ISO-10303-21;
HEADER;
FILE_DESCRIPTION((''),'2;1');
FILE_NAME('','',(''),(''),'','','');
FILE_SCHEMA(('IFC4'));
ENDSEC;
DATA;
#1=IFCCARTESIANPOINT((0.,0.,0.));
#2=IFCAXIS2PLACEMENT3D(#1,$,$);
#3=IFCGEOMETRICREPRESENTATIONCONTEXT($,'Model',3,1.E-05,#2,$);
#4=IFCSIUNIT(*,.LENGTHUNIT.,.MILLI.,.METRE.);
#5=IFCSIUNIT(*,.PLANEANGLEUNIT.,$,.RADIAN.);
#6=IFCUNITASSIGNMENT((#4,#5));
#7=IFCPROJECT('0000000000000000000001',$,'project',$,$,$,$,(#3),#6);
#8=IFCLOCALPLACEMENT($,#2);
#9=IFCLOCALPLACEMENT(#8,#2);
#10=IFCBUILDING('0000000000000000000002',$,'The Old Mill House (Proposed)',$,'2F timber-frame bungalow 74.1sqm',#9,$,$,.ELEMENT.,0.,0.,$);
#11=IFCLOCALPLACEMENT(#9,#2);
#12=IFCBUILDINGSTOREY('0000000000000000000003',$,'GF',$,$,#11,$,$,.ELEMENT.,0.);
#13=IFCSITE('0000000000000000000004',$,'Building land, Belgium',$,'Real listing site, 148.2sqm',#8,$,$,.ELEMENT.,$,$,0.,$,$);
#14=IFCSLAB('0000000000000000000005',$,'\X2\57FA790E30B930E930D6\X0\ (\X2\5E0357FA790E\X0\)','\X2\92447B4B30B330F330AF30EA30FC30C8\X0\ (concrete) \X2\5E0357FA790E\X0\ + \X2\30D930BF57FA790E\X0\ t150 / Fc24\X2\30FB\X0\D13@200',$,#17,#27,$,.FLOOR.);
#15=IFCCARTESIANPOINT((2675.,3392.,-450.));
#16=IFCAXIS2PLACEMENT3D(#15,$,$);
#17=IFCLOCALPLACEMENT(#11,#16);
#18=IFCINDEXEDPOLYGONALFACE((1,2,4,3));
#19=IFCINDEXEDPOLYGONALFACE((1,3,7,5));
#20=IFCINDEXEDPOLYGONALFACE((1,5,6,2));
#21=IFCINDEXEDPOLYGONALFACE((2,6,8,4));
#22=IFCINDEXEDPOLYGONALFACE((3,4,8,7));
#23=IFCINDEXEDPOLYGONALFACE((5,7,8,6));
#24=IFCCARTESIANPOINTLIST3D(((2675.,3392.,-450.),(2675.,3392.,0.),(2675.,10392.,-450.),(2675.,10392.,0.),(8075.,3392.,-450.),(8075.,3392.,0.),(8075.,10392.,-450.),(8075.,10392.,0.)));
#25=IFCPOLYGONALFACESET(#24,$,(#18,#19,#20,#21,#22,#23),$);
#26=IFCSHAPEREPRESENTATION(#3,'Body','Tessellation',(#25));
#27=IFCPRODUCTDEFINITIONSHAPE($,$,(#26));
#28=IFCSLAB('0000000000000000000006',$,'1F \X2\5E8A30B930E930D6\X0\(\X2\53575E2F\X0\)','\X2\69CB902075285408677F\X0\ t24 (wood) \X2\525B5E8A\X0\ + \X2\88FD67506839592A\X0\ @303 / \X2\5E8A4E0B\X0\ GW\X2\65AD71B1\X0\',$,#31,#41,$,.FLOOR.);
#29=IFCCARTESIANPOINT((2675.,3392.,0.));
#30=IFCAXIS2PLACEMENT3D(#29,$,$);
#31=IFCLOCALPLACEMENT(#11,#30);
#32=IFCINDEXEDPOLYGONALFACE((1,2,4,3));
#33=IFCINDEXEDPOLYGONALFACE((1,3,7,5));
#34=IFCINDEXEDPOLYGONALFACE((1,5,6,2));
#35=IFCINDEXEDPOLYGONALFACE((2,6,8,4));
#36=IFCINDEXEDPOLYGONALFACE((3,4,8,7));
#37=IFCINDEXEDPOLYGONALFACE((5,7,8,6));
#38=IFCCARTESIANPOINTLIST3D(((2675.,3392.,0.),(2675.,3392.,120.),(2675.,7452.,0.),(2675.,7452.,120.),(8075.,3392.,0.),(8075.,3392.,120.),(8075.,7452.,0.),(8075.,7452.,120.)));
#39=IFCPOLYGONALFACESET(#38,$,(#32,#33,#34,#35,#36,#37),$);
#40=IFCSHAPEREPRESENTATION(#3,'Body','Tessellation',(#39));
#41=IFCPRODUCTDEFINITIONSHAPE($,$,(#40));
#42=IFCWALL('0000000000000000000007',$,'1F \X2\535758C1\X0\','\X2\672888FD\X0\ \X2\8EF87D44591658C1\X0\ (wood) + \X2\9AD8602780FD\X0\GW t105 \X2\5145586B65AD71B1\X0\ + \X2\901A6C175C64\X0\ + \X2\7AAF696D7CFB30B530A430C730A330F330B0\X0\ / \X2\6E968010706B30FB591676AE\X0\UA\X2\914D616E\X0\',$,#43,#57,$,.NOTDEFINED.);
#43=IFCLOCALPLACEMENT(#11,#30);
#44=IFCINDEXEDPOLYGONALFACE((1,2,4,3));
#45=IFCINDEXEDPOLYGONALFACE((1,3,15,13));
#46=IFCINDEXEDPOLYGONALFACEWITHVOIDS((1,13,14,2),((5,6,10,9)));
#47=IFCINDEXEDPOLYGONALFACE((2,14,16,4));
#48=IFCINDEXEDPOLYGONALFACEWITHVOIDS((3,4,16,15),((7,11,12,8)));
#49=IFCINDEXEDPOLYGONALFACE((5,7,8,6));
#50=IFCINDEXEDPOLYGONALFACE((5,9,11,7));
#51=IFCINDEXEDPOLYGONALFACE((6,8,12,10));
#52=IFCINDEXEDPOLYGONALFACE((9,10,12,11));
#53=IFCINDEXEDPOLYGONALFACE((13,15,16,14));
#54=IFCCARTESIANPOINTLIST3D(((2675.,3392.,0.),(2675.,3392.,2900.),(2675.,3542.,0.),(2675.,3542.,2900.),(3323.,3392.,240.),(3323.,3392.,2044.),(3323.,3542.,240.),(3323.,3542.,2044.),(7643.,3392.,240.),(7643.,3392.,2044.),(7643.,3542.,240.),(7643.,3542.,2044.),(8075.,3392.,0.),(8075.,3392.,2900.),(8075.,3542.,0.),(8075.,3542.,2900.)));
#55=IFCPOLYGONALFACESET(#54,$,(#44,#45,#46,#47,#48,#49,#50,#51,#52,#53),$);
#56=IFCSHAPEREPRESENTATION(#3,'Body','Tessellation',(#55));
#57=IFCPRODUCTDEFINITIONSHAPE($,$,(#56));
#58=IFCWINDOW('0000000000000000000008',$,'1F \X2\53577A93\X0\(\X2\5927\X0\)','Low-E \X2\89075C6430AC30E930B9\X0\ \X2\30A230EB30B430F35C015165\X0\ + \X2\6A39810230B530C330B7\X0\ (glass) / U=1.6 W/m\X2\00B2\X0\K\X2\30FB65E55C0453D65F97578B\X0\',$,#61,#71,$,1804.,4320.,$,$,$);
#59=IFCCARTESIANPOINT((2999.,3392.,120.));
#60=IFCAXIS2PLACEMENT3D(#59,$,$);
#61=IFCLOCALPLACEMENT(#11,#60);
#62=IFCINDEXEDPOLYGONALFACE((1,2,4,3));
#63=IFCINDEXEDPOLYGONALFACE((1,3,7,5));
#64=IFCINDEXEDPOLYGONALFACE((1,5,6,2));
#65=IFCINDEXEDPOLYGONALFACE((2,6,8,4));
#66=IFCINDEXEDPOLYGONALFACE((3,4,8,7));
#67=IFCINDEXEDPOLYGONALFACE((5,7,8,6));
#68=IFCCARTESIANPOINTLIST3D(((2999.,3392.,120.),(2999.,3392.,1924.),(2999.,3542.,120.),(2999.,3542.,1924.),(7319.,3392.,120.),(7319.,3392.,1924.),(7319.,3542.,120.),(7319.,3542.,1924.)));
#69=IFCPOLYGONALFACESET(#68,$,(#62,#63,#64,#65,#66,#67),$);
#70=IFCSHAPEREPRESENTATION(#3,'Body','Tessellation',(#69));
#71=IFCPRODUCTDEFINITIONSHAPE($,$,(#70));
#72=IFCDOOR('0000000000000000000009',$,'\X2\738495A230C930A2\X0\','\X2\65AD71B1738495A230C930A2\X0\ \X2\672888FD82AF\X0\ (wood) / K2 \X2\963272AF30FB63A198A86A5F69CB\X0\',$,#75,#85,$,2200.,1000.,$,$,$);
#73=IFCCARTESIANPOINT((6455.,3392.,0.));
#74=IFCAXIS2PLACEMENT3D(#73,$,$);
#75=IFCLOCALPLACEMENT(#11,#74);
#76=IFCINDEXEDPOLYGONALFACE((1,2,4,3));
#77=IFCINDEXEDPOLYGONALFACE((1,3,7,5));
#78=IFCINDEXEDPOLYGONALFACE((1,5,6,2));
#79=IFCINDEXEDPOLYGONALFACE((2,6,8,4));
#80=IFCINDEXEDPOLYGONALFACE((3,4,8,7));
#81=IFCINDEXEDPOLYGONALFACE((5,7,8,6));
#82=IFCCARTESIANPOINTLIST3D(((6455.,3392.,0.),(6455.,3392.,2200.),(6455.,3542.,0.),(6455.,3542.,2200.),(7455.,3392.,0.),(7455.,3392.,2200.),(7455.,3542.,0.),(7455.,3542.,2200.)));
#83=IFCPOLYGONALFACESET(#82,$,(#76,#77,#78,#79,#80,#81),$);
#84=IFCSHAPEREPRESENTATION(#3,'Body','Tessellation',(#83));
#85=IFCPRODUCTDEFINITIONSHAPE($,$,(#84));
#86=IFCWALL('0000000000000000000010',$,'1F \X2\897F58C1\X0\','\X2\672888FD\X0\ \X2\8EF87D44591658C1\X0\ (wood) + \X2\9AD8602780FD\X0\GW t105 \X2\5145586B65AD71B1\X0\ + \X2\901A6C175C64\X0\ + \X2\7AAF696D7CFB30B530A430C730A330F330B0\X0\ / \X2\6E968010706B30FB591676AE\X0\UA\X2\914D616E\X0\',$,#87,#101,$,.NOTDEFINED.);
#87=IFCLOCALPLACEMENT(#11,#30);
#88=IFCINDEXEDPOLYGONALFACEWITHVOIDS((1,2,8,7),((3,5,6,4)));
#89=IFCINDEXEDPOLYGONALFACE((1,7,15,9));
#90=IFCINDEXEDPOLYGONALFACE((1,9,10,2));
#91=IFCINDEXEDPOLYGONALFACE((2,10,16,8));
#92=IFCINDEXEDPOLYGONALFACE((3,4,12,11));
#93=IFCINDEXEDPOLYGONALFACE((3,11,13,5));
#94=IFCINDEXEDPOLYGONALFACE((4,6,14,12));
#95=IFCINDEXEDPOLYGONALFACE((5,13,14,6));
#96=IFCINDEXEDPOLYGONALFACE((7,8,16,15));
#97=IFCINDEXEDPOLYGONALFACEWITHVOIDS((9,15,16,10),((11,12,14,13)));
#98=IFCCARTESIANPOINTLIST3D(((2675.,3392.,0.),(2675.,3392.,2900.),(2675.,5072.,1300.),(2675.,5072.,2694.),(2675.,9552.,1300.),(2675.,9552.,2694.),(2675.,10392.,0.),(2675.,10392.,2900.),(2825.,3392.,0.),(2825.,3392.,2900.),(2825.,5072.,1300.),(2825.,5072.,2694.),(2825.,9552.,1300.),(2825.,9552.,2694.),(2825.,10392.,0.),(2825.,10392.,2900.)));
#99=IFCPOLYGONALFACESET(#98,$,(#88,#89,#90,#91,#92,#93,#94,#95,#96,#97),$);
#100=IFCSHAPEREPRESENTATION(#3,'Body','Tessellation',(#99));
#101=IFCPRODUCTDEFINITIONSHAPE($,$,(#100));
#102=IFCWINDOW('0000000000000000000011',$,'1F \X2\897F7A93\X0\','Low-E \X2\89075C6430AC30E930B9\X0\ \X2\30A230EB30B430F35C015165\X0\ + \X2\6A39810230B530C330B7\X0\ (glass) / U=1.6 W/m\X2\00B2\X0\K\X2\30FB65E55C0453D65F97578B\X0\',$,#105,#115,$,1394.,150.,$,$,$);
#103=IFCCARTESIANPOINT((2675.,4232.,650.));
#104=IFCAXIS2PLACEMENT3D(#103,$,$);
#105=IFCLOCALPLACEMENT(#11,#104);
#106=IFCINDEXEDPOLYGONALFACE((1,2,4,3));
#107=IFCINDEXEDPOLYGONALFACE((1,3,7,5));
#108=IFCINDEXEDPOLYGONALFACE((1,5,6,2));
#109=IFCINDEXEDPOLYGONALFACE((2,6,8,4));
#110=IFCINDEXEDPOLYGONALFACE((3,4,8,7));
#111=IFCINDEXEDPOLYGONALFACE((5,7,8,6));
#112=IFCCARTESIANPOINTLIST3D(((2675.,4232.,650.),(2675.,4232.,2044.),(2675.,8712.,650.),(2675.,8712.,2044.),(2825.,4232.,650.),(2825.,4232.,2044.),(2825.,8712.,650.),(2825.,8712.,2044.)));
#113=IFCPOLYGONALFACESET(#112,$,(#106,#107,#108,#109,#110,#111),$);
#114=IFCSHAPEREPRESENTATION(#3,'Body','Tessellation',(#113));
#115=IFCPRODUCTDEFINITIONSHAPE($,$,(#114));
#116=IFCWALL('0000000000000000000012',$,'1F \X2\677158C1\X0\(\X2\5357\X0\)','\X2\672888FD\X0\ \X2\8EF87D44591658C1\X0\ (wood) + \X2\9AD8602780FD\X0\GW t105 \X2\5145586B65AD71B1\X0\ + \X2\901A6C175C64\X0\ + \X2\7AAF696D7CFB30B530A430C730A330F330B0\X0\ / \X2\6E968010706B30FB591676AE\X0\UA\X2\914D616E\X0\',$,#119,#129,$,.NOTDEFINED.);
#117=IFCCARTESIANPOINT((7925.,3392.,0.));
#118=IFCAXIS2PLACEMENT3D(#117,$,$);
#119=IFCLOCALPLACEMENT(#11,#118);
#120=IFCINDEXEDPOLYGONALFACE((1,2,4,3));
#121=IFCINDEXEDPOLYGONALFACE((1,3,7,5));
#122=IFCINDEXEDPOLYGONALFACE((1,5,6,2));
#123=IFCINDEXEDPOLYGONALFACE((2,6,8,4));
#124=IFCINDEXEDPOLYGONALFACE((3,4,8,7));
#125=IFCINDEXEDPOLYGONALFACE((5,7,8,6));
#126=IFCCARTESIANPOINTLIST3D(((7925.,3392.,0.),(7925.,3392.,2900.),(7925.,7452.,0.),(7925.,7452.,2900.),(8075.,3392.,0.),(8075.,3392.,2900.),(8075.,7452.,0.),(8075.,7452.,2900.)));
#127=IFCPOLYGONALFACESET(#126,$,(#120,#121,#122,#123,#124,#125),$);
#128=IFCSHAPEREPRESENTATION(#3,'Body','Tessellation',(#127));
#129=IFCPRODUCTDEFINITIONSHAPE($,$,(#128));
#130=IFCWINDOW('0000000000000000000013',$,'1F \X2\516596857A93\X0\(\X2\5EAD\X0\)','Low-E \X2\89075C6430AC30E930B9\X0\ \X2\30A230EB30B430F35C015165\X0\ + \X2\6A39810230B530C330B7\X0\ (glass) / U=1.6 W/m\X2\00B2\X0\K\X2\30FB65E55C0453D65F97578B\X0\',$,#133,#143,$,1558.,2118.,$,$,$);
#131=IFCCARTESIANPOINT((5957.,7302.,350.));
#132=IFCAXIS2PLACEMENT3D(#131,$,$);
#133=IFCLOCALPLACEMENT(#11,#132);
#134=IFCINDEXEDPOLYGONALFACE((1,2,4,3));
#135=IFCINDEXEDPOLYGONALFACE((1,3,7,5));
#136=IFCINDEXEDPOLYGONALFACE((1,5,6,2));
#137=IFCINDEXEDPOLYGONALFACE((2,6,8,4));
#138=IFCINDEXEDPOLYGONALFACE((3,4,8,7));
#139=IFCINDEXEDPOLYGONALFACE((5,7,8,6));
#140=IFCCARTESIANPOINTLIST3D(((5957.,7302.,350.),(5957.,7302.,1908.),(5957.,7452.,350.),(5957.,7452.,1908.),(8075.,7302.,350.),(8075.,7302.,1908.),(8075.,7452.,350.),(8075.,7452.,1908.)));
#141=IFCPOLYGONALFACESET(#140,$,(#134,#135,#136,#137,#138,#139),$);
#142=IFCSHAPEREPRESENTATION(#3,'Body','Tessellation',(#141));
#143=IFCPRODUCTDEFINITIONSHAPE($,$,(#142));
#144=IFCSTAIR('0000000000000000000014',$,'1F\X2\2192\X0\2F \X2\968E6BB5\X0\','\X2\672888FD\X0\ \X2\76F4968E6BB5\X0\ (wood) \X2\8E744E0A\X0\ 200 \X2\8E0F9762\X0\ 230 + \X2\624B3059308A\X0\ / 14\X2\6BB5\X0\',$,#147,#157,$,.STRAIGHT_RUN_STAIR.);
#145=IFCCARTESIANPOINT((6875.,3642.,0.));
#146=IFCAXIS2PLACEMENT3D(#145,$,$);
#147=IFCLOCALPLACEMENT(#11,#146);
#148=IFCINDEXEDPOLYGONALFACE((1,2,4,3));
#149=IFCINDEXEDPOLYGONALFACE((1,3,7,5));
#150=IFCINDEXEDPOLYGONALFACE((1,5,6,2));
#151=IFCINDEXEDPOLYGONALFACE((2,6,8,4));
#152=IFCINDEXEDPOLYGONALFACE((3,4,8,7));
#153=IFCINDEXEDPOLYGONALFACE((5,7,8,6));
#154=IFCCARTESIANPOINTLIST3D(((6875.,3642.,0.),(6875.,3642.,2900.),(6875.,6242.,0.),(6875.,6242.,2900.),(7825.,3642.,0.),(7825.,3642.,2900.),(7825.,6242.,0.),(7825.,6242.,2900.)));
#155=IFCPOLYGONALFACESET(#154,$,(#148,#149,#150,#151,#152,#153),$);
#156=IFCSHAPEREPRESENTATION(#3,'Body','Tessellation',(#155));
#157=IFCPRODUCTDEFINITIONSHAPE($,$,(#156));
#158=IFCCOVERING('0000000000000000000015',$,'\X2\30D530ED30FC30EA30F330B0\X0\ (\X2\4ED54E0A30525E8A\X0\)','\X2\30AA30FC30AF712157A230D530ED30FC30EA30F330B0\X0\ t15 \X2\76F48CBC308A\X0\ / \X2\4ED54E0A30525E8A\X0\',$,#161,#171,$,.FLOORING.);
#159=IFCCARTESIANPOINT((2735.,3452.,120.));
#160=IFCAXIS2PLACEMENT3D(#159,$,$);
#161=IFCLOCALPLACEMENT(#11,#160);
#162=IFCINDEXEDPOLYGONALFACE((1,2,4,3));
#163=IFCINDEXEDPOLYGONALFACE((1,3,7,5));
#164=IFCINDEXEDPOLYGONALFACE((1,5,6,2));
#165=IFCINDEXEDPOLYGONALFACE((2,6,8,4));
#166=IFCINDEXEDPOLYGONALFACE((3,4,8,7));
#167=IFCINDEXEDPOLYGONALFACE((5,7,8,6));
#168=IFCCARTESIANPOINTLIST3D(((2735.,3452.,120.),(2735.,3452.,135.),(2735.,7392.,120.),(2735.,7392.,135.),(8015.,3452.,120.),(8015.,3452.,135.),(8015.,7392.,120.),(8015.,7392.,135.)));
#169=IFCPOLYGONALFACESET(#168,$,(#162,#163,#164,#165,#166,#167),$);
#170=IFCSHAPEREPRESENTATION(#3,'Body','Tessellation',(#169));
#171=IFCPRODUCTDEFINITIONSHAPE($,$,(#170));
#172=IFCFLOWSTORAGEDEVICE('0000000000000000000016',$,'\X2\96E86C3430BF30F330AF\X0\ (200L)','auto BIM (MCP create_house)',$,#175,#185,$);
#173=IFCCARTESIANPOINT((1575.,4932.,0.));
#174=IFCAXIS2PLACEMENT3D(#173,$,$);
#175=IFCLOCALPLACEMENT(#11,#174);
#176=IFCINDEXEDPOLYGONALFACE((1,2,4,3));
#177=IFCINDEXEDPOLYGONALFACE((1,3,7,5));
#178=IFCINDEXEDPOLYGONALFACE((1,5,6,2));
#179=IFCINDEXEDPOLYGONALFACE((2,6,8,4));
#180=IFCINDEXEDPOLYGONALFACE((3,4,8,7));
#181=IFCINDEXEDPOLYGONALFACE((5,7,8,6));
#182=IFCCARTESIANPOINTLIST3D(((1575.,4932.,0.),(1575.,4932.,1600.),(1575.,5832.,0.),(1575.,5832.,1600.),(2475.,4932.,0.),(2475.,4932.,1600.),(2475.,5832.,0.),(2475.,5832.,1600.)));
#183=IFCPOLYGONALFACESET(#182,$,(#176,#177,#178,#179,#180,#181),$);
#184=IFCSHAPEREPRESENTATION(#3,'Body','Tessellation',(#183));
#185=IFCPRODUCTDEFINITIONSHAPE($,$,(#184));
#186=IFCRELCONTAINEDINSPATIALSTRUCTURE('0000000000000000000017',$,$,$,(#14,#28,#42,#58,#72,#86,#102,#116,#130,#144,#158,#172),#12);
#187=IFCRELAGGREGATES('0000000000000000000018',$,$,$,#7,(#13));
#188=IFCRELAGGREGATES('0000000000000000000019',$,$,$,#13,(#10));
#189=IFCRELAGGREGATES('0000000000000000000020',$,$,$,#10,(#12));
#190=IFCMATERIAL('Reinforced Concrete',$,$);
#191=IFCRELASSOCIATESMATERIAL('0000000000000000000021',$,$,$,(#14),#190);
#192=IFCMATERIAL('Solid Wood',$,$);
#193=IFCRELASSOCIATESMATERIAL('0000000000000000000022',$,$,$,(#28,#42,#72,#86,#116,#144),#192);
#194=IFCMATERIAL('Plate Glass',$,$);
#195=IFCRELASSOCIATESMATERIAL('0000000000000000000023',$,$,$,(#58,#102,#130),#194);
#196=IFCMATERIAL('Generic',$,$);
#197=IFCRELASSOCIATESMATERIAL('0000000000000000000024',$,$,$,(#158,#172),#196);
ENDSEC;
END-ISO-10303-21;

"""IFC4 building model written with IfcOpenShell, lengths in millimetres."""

from ifc_helpers import new_model, si_unit, frame, frame_2d, origin, place, context, project, spatial, rectangle, extrude, material, element, fill, save


model = new_model("IFC4")

# Units and contexts
model_context = context("Model", 3, precision=1e-05, world=origin())
ifc_project = project(units=[si_unit("LENGTHUNIT", "METRE", prefix="MILLI"), si_unit("PLANEANGLEUNIT", "RADIAN")], contexts=[model_context])

# Site, building, storey
site_placement = place(None, origin())
site = spatial("IfcSite", under=ifc_project, at=site_placement, Name="Building land, Belgium", ObjectType="Real listing site, 148.2sqm", CompositionType="ELEMENT", RefElevation=0.0)
building_placement = place(site_placement, origin())
building = spatial("IfcBuilding", under=site, at=building_placement, Name="The Old Mill House (Proposed)", ObjectType="2F timber-frame bungalow 74.1sqm", CompositionType="ELEMENT", ElevationOfRefHeight=0.0, ElevationOfTerrain=0.0)
storey_placement = place(building_placement, origin())
storey = spatial("IfcBuildingStorey", under=building, at=storey_placement, Name="GF", CompositionType="ELEMENT", Elevation=0.0)

# Slabs
ifc_material_1 = material(Name="Reinforced Concrete")
slab_1_placement = place(storey_placement, frame((2675.0, 3392.0, -450.0)))
element("IfcSlab", 1, at=slab_1_placement, inside=storey, material=ifc_material_1, Name="基礎スラブ (布基礎)", Description="鉄筋コンクリート (concrete) 布基礎 + ベタ基礎 t150 / Fc24・D13@200", PredefinedType="FLOOR", context=model_context, shape_type="SweptSolid", body=[
    extrude(rectangle(XDim=5400.0, YDim=7000.0, at=frame_2d((2700.0, 3500.0))), frame((2675.0, 3392.0, -450.0)), (0.0, 0.0, 1.0), 450.0),
])
ifc_material_2 = material(Name="Solid Wood")
slab_2_placement = place(storey_placement, frame((2675.0, 3392.0, 0.0)))
element("IfcSlab", 2, at=slab_2_placement, inside=storey, material=ifc_material_2, Name="1F 床スラブ(南帯)", Description="構造用合板 t24 (wood) 剛床 + 製材根太 @303 / 床下 GW断熱", PredefinedType="FLOOR", context=model_context, shape_type="SweptSolid", body=[
    extrude(rectangle(XDim=5400.0, YDim=4060.0, at=frame_2d((2700.0, 2030.0))), frame((2675.0, 3392.0, 0.0)), (0.0, 0.0, 1.0), 120.0),
])

# Wall, openings, window, door
wall_1_placement = place(storey_placement, frame((2675.0, 3392.0, 0.0)))
wall_1 = element("IfcWall", 3, at=wall_1_placement, inside=storey, material=ifc_material_2, Name="1F 南壁", Description="木製 軸組外壁 (wood) + 高性能GW t105 充填断熱 + 通気層 + 窯業系サイディング / 準耐火・外皮UA配慮", PredefinedType="NOTDEFINED", context=model_context, shape_type="SweptSolid", body=[
    extrude(rectangle(XDim=5400.0, YDim=150.0, at=frame_2d((2700.0, 75.0))), frame((2675.0, 3392.0, 0.0)), (0.0, 0.0, 1.0), 2900.0),
])
opening_1_placement = place(storey_placement, frame((2999.0, 3392.0, 120.0)))
opening_1 = element("IfcOpeningElement", 4, at=opening_1_placement, cuts=wall_1, PredefinedType="NOTDEFINED", context=model_context, shape_type="SweptSolid", body=[
    extrude(rectangle(XDim=4320.0, YDim=150.0, at=frame_2d((2160.0, 75.0))), frame((2999.0, 3392.0, 120.0)), (0.0, 0.0, 1.0), 1804.0),
])
opening_2_placement = place(storey_placement, frame((6455.0, 3392.0, 0.0)))
opening_2 = element("IfcOpeningElement", 5, at=opening_2_placement, cuts=wall_1, PredefinedType="NOTDEFINED", context=model_context, shape_type="SweptSolid", body=[
    extrude(rectangle(XDim=1000.0, YDim=150.0, at=frame_2d((500.0, 75.0))), frame((6455.0, 3392.0, 0.0)), (0.0, 0.0, 1.0), 2200.0),
])
ifc_material_3 = material(Name="Plate Glass")
window_1_placement = place(storey_placement, frame((2999.0, 3392.0, 120.0)))
window_1 = element("IfcWindow", 6, at=window_1_placement, inside=storey, material=ifc_material_3, Name="1F 南窓(大)", Description="Low-E 複層ガラス アルゴン封入 + 樹脂サッシ (glass) / U=1.6 W/m²K・日射取得型", OverallHeight=1804.0, OverallWidth=4320.0, context=model_context, shape_type="SweptSolid", body=[
    extrude(rectangle(XDim=4320.0, YDim=150.0, at=frame_2d((2160.0, 75.0))), frame((2999.0, 3392.0, 120.0)), (0.0, 0.0, 1.0), 1804.0),
])
fill(opening_1, window_1)
door_1_placement = place(storey_placement, frame((6455.0, 3392.0, 0.0)))
door_1 = element("IfcDoor", 7, at=door_1_placement, inside=storey, material=ifc_material_2, Name="玄関ドア", Description="断熱玄関ドア 木製芯 (wood) / K2 防犯・採風機構", OverallHeight=2200.0, OverallWidth=1000.0, context=model_context, shape_type="SweptSolid", body=[
    extrude(rectangle(XDim=1000.0, YDim=150.0, at=frame_2d((500.0, 75.0))), frame((6455.0, 3392.0, 0.0)), (0.0, 0.0, 1.0), 2200.0),
])
fill(opening_2, door_1)

# Walls, openings, windows
wall_2_placement = place(storey_placement, frame((2675.0, 3392.0, 0.0)))
wall_2 = element("IfcWall", 8, at=wall_2_placement, inside=storey, material=ifc_material_2, Name="1F 西壁", Description="木製 軸組外壁 (wood) + 高性能GW t105 充填断熱 + 通気層 + 窯業系サイディング / 準耐火・外皮UA配慮", PredefinedType="NOTDEFINED", context=model_context, shape_type="SweptSolid", body=[
    extrude(rectangle(XDim=150.0, YDim=7000.0, at=frame_2d((75.0, 3500.0))), frame((2675.0, 3392.0, 0.0)), (0.0, 0.0, 1.0), 2900.0),
])
opening_3_placement = place(storey_placement, frame((2675.0, 4232.0, 650.0)))
opening_3 = element("IfcOpeningElement", 9, at=opening_3_placement, cuts=wall_2, PredefinedType="NOTDEFINED", context=model_context, shape_type="SweptSolid", body=[
    extrude(rectangle(XDim=150.0, YDim=4480.0, at=frame_2d((75.0, 2240.0))), frame((2675.0, 4232.0, 650.0)), (0.0, 0.0, 1.0), 1394.0),
])
window_2_placement = place(storey_placement, frame((2675.0, 4232.0, 650.0)))
window_2 = element("IfcWindow", 10, at=window_2_placement, inside=storey, material=ifc_material_3, Name="1F 西窓", Description="Low-E 複層ガラス アルゴン封入 + 樹脂サッシ (glass) / U=1.6 W/m²K・日射取得型", OverallHeight=1394.0, OverallWidth=150.0, context=model_context, shape_type="SweptSolid", body=[
    extrude(rectangle(XDim=150.0, YDim=4480.0, at=frame_2d((75.0, 2240.0))), frame((2675.0, 4232.0, 650.0)), (0.0, 0.0, 1.0), 1394.0),
])
fill(opening_3, window_2)
wall_3_placement = place(storey_placement, frame((7925.0, 3392.0, 0.0)))
wall_3 = element("IfcWall", 11, at=wall_3_placement, inside=storey, material=ifc_material_2, Name="1F 東壁(南)", Description="木製 軸組外壁 (wood) + 高性能GW t105 充填断熱 + 通気層 + 窯業系サイディング / 準耐火・外皮UA配慮", PredefinedType="NOTDEFINED", context=model_context, shape_type="SweptSolid", body=[
    extrude(rectangle(XDim=150.0, YDim=4060.0, at=frame_2d((75.0, 2030.0))), frame((7925.0, 3392.0, 0.0)), (0.0, 0.0, 1.0), 2900.0),
])
opening_4_placement = place(storey_placement, frame((5957.0, 7302.0, 350.0)))
opening_4 = element("IfcOpeningElement", 12, at=opening_4_placement, cuts=wall_3, PredefinedType="NOTDEFINED", context=model_context, shape_type="SweptSolid", body=[
    extrude(rectangle(XDim=2118.0, YDim=150.0, at=frame_2d((1059.0, 75.0))), frame((5957.0, 7302.0, 350.0)), (0.0, 0.0, 1.0), 1558.0),
])
window_3_placement = place(storey_placement, frame((5957.0, 7302.0, 350.0)))
window_3 = element("IfcWindow", 13, at=window_3_placement, inside=storey, material=ifc_material_3, Name="1F 入隅窓(庭)", Description="Low-E 複層ガラス アルゴン封入 + 樹脂サッシ (glass) / U=1.6 W/m²K・日射取得型", OverallHeight=1558.0, OverallWidth=2118.0, context=model_context, shape_type="SweptSolid", body=[
    extrude(rectangle(XDim=2118.0, YDim=150.0, at=frame_2d((1059.0, 75.0))), frame((5957.0, 7302.0, 350.0)), (0.0, 0.0, 1.0), 1558.0),
])
fill(opening_4, window_3)

# Stair
stair_placement = place(storey_placement, frame((6875.0, 3642.0, 0.0)))
element("IfcStair", 14, at=stair_placement, inside=storey, material=ifc_material_2, Name="1F→2F 階段", Description="木製 直階段 (wood) 蹴上 200 踏面 230 + 手すり / 14段", PredefinedType="STRAIGHT_RUN_STAIR", context=model_context, shape_type="SweptSolid", body=[
    extrude(rectangle(XDim=950.0, YDim=2600.0, at=frame_2d((475.0, 1300.0))), frame((6875.0, 3642.0, 0.0)), (0.0, 0.0, 1.0), 2900.0),
])

# Covering
ifc_material_4 = material(Name="Generic")
covering_placement = place(storey_placement, frame((2735.0, 3452.0, 120.0)))
element("IfcCovering", 15, at=covering_placement, inside=storey, material=ifc_material_4, Name="フローリング (仕上げ床)", Description="オーク無垢フローリング t15 直貼り / 仕上げ床", PredefinedType="FLOORING", context=model_context, shape_type="SweptSolid", body=[
    extrude(rectangle(XDim=5280.0, YDim=3940.0, at=frame_2d((2640.0, 1970.0))), frame((2735.0, 3452.0, 120.0)), (0.0, 0.0, 1.0), 15.0),
])

# Flow storage device
flow_storage_device_placement = place(storey_placement, frame((1575.0, 4932.0, 0.0)))
element("IfcFlowStorageDevice", 16, at=flow_storage_device_placement, inside=storey, material=ifc_material_4, Name="雨水タンク (200L)", Description="auto BIM (MCP create_house)", context=model_context, shape_type="SweptSolid", body=[
    extrude(rectangle(XDim=900.0, YDim=900.0, at=frame_2d((450.0, 450.0))), frame((1575.0, 4932.0, 0.0)), (0.0, 0.0, 1.0), 1600.0),
])

save(model, "model.ifc")
